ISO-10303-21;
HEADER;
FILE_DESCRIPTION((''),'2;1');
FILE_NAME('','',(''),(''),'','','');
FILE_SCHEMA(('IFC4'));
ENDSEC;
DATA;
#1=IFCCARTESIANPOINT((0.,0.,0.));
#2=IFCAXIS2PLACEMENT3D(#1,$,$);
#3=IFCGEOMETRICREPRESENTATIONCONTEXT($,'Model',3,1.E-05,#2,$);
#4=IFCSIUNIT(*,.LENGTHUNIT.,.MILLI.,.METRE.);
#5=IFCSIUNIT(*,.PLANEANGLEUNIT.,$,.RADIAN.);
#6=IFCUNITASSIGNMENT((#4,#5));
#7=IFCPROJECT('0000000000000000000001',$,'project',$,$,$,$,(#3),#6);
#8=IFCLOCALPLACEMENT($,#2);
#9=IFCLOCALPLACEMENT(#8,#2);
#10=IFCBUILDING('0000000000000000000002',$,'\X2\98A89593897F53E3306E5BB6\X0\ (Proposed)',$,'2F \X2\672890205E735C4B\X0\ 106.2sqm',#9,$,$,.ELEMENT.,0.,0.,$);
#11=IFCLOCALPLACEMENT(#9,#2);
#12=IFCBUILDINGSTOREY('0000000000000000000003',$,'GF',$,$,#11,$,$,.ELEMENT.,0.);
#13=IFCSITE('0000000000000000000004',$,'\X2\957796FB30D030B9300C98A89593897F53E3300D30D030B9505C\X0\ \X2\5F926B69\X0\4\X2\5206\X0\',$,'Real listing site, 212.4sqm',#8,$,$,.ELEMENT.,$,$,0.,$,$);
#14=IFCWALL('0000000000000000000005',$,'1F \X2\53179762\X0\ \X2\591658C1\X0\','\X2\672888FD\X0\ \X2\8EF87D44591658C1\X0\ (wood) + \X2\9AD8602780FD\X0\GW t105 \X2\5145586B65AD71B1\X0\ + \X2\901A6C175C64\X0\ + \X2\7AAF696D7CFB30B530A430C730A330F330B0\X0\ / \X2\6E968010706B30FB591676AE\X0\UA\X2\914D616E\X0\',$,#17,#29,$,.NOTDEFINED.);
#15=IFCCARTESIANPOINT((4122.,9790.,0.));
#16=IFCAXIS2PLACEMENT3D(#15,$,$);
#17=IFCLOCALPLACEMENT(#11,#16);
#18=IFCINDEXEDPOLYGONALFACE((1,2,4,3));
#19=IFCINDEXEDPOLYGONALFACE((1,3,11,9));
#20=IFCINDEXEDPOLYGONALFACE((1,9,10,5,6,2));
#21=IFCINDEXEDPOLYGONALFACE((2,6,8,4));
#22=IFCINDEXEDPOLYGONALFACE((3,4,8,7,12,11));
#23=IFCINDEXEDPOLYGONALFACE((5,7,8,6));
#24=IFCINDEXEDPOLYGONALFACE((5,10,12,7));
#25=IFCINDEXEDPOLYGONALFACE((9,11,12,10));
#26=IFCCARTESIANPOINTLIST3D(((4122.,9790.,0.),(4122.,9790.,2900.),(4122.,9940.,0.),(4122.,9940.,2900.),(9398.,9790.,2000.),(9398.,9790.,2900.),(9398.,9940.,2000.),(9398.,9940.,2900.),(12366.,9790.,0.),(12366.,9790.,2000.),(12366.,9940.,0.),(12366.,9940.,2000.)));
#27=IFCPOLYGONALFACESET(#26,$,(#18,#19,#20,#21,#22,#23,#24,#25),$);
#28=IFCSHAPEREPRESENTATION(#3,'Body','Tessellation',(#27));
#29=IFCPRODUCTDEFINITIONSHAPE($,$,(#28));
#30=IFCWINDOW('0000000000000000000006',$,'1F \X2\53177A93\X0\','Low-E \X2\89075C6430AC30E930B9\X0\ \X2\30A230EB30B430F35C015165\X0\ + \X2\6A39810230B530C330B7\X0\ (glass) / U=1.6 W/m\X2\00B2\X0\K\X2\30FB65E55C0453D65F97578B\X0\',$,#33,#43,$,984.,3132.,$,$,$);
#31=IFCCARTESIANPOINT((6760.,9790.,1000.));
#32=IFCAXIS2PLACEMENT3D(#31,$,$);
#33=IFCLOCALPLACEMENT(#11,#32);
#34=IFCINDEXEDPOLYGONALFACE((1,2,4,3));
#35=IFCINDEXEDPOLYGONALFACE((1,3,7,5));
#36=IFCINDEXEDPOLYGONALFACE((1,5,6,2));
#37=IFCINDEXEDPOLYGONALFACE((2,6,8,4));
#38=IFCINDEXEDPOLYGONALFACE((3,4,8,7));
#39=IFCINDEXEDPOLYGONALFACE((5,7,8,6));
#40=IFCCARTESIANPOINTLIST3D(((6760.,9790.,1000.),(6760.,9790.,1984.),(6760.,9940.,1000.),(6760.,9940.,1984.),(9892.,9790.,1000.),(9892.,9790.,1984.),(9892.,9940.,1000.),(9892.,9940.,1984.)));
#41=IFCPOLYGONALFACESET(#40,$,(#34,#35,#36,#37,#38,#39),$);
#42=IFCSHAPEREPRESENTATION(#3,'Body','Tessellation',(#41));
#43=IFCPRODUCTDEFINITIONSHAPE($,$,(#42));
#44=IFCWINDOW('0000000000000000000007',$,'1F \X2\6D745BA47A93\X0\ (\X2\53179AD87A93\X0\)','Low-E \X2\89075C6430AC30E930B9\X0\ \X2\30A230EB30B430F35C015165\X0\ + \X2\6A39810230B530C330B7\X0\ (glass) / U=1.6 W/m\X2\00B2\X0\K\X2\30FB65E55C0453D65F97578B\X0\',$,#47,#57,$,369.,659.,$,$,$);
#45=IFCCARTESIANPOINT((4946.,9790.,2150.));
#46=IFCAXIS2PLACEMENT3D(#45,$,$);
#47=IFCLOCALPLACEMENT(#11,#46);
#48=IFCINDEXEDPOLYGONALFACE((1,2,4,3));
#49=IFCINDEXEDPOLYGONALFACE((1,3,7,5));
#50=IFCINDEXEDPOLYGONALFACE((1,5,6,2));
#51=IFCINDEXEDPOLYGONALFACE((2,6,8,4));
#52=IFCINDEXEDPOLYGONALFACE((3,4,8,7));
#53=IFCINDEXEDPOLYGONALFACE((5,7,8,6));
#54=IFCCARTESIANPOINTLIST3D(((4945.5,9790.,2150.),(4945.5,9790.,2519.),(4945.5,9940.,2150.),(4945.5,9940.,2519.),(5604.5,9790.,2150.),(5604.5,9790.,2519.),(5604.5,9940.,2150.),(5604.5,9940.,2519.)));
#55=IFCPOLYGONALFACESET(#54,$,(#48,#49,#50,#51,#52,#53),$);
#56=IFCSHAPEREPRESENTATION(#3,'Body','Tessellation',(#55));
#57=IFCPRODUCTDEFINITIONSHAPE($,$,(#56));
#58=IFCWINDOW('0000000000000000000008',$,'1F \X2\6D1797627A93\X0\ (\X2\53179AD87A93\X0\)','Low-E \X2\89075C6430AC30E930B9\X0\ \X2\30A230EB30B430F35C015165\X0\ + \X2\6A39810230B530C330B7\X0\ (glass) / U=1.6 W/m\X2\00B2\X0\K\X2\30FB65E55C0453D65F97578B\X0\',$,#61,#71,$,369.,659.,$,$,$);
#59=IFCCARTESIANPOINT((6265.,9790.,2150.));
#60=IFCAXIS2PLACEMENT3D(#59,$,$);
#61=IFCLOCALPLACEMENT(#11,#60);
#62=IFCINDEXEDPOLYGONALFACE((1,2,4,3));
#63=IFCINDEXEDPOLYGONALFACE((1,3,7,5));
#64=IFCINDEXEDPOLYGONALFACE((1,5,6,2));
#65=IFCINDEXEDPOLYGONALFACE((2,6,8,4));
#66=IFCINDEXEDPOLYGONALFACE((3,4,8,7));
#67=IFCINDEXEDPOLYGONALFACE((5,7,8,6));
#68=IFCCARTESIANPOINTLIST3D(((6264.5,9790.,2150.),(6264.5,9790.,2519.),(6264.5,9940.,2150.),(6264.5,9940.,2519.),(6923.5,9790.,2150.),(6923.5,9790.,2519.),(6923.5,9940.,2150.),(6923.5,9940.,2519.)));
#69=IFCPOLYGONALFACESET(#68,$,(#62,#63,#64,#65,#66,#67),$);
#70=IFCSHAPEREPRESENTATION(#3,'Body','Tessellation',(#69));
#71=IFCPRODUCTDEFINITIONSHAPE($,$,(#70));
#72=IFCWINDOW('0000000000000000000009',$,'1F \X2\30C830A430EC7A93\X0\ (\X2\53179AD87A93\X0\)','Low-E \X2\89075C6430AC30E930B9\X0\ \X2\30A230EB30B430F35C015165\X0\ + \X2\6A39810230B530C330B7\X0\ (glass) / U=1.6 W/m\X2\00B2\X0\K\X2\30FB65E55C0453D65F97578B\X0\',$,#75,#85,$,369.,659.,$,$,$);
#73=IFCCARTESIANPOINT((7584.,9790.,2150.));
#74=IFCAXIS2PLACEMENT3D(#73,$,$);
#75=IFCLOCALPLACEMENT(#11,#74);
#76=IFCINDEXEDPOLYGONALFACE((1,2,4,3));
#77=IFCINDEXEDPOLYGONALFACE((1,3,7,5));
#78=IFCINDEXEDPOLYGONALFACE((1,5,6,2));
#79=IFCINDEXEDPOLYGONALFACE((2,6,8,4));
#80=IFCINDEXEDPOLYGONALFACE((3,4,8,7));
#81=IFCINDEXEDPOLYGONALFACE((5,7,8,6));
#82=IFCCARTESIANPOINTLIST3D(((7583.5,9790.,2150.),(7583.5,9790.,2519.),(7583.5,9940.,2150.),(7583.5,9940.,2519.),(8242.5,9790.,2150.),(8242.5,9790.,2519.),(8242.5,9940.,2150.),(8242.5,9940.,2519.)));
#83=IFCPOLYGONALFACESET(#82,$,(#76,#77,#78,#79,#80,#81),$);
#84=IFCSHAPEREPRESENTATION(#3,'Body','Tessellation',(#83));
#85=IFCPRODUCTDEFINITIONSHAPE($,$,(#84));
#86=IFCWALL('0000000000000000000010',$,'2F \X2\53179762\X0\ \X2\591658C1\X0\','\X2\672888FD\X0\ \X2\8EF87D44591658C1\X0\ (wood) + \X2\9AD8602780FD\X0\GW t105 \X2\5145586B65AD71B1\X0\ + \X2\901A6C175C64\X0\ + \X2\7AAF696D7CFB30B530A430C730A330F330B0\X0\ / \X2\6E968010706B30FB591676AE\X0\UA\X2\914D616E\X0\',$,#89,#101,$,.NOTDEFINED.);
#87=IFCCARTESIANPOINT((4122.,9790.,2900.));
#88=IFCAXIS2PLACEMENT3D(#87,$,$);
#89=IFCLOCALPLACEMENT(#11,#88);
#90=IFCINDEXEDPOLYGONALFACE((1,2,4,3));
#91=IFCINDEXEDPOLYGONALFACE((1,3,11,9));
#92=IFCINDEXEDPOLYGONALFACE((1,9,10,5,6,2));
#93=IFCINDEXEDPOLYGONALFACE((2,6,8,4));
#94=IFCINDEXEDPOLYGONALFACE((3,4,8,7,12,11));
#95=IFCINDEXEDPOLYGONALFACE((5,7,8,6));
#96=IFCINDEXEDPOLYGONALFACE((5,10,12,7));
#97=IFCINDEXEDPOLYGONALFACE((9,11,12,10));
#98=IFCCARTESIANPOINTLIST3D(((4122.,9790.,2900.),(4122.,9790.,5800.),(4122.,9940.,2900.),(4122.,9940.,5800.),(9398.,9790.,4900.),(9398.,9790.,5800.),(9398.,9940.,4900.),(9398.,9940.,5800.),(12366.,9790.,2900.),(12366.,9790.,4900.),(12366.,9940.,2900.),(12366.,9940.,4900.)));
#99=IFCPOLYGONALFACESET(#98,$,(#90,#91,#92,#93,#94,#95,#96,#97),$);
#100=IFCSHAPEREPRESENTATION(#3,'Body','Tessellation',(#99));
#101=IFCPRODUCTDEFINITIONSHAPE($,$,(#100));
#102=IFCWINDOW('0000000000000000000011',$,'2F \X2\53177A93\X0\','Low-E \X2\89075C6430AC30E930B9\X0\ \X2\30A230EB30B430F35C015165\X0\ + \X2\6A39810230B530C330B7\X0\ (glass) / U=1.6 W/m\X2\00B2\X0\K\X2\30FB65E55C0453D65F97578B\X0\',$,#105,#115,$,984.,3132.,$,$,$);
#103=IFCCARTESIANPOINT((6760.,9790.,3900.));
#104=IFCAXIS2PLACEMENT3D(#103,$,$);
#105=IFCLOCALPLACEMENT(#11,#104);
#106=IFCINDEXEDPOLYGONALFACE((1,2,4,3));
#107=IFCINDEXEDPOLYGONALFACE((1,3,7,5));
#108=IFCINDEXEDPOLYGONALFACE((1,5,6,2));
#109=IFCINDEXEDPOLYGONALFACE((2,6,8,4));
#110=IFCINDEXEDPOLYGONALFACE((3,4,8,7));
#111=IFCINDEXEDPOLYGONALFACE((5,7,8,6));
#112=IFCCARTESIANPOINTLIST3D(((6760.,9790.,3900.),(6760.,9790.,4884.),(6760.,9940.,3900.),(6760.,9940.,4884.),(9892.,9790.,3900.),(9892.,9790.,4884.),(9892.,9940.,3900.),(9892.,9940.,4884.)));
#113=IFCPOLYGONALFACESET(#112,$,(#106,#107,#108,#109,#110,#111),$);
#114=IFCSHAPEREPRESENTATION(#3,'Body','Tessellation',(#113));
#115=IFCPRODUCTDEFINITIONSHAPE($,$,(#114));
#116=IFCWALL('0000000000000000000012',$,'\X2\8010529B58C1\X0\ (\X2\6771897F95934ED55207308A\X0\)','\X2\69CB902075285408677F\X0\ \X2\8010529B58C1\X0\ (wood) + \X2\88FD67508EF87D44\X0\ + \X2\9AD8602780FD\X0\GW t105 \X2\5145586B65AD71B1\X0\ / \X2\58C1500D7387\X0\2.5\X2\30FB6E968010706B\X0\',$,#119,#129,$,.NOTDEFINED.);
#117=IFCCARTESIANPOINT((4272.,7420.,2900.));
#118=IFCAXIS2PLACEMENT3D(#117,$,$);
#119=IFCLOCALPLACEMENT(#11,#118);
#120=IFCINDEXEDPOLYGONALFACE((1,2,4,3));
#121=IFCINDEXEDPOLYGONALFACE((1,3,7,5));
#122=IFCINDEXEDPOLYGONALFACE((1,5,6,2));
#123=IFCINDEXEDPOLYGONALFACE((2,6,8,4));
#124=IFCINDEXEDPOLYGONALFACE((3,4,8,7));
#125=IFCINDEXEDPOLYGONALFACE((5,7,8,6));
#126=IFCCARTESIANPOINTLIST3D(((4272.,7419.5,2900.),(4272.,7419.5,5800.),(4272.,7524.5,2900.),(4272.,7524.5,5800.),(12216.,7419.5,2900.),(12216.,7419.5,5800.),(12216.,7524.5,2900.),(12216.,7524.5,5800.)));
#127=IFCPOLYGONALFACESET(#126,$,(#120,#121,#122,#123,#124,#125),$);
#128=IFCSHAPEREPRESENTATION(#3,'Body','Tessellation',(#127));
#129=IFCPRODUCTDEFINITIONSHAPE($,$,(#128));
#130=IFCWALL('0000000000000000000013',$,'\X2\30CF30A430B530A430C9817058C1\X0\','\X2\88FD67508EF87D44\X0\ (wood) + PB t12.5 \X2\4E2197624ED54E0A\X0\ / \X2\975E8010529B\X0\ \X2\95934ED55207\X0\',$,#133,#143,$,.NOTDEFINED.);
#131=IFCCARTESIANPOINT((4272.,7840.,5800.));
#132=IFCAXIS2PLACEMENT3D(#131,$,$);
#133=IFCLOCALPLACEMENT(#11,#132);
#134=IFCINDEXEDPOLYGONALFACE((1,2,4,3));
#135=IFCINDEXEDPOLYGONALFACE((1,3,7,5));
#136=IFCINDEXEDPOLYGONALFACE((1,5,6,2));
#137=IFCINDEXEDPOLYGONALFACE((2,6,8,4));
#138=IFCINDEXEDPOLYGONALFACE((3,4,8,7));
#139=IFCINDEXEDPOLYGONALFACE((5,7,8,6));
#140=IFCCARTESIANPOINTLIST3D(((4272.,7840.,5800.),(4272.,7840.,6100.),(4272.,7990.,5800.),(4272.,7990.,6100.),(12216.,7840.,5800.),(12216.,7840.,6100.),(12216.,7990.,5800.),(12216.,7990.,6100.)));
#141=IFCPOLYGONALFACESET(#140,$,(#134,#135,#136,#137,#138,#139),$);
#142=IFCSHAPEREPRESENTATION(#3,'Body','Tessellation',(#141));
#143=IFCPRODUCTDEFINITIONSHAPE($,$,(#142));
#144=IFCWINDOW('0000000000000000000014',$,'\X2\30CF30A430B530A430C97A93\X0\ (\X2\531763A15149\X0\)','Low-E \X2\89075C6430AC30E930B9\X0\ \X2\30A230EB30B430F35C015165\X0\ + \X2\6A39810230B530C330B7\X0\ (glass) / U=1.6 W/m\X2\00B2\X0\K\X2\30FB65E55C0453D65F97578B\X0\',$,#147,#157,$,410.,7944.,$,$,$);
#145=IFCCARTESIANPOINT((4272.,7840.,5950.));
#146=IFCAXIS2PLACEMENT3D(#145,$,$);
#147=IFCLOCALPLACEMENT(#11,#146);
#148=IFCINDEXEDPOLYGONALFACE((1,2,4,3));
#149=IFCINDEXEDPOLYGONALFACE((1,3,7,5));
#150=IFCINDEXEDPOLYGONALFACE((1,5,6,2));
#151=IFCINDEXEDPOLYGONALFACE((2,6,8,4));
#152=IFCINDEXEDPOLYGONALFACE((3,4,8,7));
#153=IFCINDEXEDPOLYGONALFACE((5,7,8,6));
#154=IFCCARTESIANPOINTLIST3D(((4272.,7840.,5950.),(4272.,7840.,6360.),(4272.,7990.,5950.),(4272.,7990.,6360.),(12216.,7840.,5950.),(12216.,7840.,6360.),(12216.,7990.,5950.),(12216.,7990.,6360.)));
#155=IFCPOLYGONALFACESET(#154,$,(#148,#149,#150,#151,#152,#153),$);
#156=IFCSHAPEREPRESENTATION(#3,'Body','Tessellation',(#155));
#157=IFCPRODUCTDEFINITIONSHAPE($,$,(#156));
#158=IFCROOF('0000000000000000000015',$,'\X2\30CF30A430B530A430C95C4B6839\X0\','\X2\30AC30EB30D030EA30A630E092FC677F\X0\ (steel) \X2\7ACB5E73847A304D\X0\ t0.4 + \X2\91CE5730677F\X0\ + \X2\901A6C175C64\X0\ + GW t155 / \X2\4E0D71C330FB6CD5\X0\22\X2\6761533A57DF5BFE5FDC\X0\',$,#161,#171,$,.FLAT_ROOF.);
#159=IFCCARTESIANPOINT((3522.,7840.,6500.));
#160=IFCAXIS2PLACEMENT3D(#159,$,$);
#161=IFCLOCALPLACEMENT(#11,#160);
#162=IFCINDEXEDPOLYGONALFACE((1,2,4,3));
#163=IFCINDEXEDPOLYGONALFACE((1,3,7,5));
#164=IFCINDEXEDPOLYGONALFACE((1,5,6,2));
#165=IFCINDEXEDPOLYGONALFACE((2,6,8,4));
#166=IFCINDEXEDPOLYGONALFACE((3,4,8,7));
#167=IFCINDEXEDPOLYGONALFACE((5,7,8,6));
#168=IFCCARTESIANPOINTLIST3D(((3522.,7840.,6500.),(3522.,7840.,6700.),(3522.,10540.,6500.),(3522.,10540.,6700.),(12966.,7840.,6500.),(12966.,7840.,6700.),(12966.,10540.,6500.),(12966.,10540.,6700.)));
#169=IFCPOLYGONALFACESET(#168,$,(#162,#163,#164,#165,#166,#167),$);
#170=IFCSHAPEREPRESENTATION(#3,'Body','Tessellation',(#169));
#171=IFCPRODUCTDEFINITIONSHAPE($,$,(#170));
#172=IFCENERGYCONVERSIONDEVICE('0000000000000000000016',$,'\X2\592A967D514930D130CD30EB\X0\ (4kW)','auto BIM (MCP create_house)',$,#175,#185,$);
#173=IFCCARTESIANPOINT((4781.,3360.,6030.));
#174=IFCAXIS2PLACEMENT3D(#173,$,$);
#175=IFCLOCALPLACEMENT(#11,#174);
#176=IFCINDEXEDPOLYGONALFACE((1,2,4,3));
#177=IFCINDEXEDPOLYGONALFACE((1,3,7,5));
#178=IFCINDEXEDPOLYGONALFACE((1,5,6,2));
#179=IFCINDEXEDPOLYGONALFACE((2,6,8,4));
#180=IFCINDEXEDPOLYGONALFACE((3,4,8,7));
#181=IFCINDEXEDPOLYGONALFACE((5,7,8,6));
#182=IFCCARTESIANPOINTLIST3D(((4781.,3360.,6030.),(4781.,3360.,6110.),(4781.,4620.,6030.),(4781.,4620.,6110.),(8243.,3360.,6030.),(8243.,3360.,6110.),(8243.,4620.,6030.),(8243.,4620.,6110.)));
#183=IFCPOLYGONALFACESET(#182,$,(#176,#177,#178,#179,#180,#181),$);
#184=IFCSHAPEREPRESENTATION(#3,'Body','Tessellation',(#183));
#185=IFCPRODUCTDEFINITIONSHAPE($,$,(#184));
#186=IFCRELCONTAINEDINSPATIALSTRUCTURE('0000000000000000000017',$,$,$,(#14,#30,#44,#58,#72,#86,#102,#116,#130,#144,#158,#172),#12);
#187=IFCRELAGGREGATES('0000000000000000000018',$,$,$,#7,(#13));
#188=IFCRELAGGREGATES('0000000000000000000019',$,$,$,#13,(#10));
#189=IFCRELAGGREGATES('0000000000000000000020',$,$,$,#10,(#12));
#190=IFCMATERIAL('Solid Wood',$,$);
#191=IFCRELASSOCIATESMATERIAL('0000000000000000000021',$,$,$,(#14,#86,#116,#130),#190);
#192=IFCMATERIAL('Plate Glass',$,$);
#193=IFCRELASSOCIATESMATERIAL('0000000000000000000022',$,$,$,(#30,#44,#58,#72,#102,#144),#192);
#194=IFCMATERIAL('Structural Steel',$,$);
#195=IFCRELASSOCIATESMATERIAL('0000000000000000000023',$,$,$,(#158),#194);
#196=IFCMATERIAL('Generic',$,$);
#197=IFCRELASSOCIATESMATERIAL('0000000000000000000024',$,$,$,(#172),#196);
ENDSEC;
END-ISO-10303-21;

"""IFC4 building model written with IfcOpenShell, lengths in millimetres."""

from ifc_helpers import new_model, si_unit, frame, frame_2d, origin, place, context, project, spatial, rectangle, extrude, material, element, fill, save


model = new_model("IFC4")

# Units and contexts
model_context = context("Model", 3, precision=1e-05, world=origin())
ifc_project = project(units=[si_unit("LENGTHUNIT", "METRE", prefix="MILLI"), si_unit("PLANEANGLEUNIT", "RADIAN")], contexts=[model_context])

# Site, building, storey
site_placement = place(None, origin())
site = spatial("IfcSite", under=ifc_project, at=site_placement, Name="長電バス「風間西口」バス停 徒歩4分", ObjectType="Real listing site, 212.4sqm", CompositionType="ELEMENT", RefElevation=0.0)
building_placement = place(site_placement, origin())
building = spatial("IfcBuilding", under=site, at=building_placement, Name="風間西口の家 (Proposed)", ObjectType="2F 木造平屋 106.2sqm", CompositionType="ELEMENT", ElevationOfRefHeight=0.0, ElevationOfTerrain=0.0)
storey_placement = place(building_placement, origin())
storey = spatial("IfcBuildingStorey", under=building, at=storey_placement, Name="GF", CompositionType="ELEMENT", Elevation=0.0)

# Wall, openings, windows
ifc_material_1 = material(Name="Solid Wood")
wall_1_placement = place(storey_placement, frame((4122.0, 9790.0, 0.0)))
wall_1 = element("IfcWall", 1, at=wall_1_placement, inside=storey, material=ifc_material_1, Name="1F 北面 外壁", Description="木製 軸組外壁 (wood) + 高性能GW t105 充填断熱 + 通気層 + 窯業系サイディング / 準耐火・外皮UA配慮", PredefinedType="NOTDEFINED", context=model_context, shape_type="SweptSolid", body=[
    extrude(rectangle(XDim=8244.0, YDim=150.0, at=frame_2d((4122.0, 75.0))), frame((4122.0, 9790.0, 0.0)), (0.0, 0.0, 1.0), 2900.0),
])
opening_1_placement = place(storey_placement, frame((6760.0, 9790.0, 1000.0)))
opening_1 = element("IfcOpeningElement", 2, at=opening_1_placement, cuts=wall_1, PredefinedType="NOTDEFINED", context=model_context, shape_type="SweptSolid", body=[
    extrude(rectangle(XDim=3132.0, YDim=150.0, at=frame_2d((1566.0, 75.0))), frame((6760.0, 9790.0, 1000.0)), (0.0, 0.0, 1.0), 984.0),
])
opening_2_placement = place(storey_placement, frame((4946.0, 9790.0, 2150.0)))
opening_2 = element("IfcOpeningElement", 3, at=opening_2_placement, cuts=wall_1, PredefinedType="NOTDEFINED", context=model_context, shape_type="SweptSolid", body=[
    extrude(rectangle(XDim=659.0, YDim=150.0, at=frame_2d((329.0, 75.0))), frame((4946.0, 9790.0, 2150.0)), (0.0, 0.0, 1.0), 369.0),
])
opening_3_placement = place(storey_placement, frame((6265.0, 9790.0, 2150.0)))
opening_3 = element("IfcOpeningElement", 4, at=opening_3_placement, cuts=wall_1, PredefinedType="NOTDEFINED", context=model_context, shape_type="SweptSolid", body=[
    extrude(rectangle(XDim=659.0, YDim=150.0, at=frame_2d((329.0, 75.0))), frame((6265.0, 9790.0, 2150.0)), (0.0, 0.0, 1.0), 369.0),
])
opening_4_placement = place(storey_placement, frame((7584.0, 9790.0, 2150.0)))
opening_4 = element("IfcOpeningElement", 5, at=opening_4_placement, cuts=wall_1, PredefinedType="NOTDEFINED", context=model_context, shape_type="SweptSolid", body=[
    extrude(rectangle(XDim=659.0, YDim=150.0, at=frame_2d((329.0, 75.0))), frame((7584.0, 9790.0, 2150.0)), (0.0, 0.0, 1.0), 369.0),
])
ifc_material_2 = material(Name="Plate Glass")
window_1_placement = place(storey_placement, frame((6760.0, 9790.0, 1000.0)))
window_1 = element("IfcWindow", 6, at=window_1_placement, inside=storey, material=ifc_material_2, Name="1F 北窓", Description="Low-E 複層ガラス アルゴン封入 + 樹脂サッシ (glass) / U=1.6 W/m²K・日射取得型", OverallHeight=984.0, OverallWidth=3132.0, context=model_context, shape_type="SweptSolid", body=[
    extrude(rectangle(XDim=3132.0, YDim=150.0, at=frame_2d((1566.0, 75.0))), frame((6760.0, 9790.0, 1000.0)), (0.0, 0.0, 1.0), 984.0),
])
fill(opening_1, window_1)
window_2_placement = place(storey_placement, frame((4946.0, 9790.0, 2150.0)))
window_2 = element("IfcWindow", 7, at=window_2_placement, inside=storey, material=ifc_material_2, Name="1F 浴室窓 (北高窓)", Description="Low-E 複層ガラス アルゴン封入 + 樹脂サッシ (glass) / U=1.6 W/m²K・日射取得型", OverallHeight=369.0, OverallWidth=659.0, context=model_context, shape_type="SweptSolid", body=[
    extrude(rectangle(XDim=659.0, YDim=150.0, at=frame_2d((329.0, 75.0))), frame((4946.0, 9790.0, 2150.0)), (0.0, 0.0, 1.0), 369.0),
])
fill(opening_2, window_2)
window_3_placement = place(storey_placement, frame((6265.0, 9790.0, 2150.0)))
window_3 = element("IfcWindow", 8, at=window_3_placement, inside=storey, material=ifc_material_2, Name="1F 洗面窓 (北高窓)", Description="Low-E 複層ガラス アルゴン封入 + 樹脂サッシ (glass) / U=1.6 W/m²K・日射取得型", OverallHeight=369.0, OverallWidth=659.0, context=model_context, shape_type="SweptSolid", body=[
    extrude(rectangle(XDim=659.0, YDim=150.0, at=frame_2d((329.0, 75.0))), frame((6265.0, 9790.0, 2150.0)), (0.0, 0.0, 1.0), 369.0),
])
fill(opening_3, window_3)
window_4_placement = place(storey_placement, frame((7584.0, 9790.0, 2150.0)))
window_4 = element("IfcWindow", 9, at=window_4_placement, inside=storey, material=ifc_material_2, Name="1F トイレ窓 (北高窓)", Description="Low-E 複層ガラス アルゴン封入 + 樹脂サッシ (glass) / U=1.6 W/m²K・日射取得型", OverallHeight=369.0, OverallWidth=659.0, context=model_context, shape_type="SweptSolid", body=[
    extrude(rectangle(XDim=659.0, YDim=150.0, at=frame_2d((329.0, 75.0))), frame((7584.0, 9790.0, 2150.0)), (0.0, 0.0, 1.0), 369.0),
])
fill(opening_4, window_4)

# Wall, opening, window
wall_2_placement = place(storey_placement, frame((4122.0, 9790.0, 2900.0)))
wall_2 = element("IfcWall", 10, at=wall_2_placement, inside=storey, material=ifc_material_1, Name="2F 北面 外壁", Description="木製 軸組外壁 (wood) + 高性能GW t105 充填断熱 + 通気層 + 窯業系サイディング / 準耐火・外皮UA配慮", PredefinedType="NOTDEFINED", context=model_context, shape_type="SweptSolid", body=[
    extrude(rectangle(XDim=8244.0, YDim=150.0, at=frame_2d((4122.0, 75.0))), frame((4122.0, 9790.0, 2900.0)), (0.0, 0.0, 1.0), 2900.0),
])
opening_5_placement = place(storey_placement, frame((6760.0, 9790.0, 3900.0)))
opening_5 = element("IfcOpeningElement", 11, at=opening_5_placement, cuts=wall_2, PredefinedType="NOTDEFINED", context=model_context, shape_type="SweptSolid", body=[
    extrude(rectangle(XDim=3132.0, YDim=150.0, at=frame_2d((1566.0, 75.0))), frame((6760.0, 9790.0, 3900.0)), (0.0, 0.0, 1.0), 984.0),
])
window_5_placement = place(storey_placement, frame((6760.0, 9790.0, 3900.0)))
window_5 = element("IfcWindow", 12, at=window_5_placement, inside=storey, material=ifc_material_2, Name="2F 北窓", Description="Low-E 複層ガラス アルゴン封入 + 樹脂サッシ (glass) / U=1.6 W/m²K・日射取得型", OverallHeight=984.0, OverallWidth=3132.0, context=model_context, shape_type="SweptSolid", body=[
    extrude(rectangle(XDim=3132.0, YDim=150.0, at=frame_2d((1566.0, 75.0))), frame((6760.0, 9790.0, 3900.0)), (0.0, 0.0, 1.0), 984.0),
])
fill(opening_5, window_5)

# Wall
wall_3_placement = place(storey_placement, frame((4272.0, 7420.0, 2900.0)))
element("IfcWall", 13, at=wall_3_placement, inside=storey, material=ifc_material_1, Name="耐力壁 (東西間仕切り)", Description="構造用合板 耐力壁 (wood) + 製材軸組 + 高性能GW t105 充填断熱 / 壁倍率2.5・準耐火", PredefinedType="NOTDEFINED", context=model_context, shape_type="SweptSolid", body=[
    extrude(rectangle(XDim=7944.0, YDim=105.0, at=frame_2d((3972.0, 52.0))), frame((4272.0, 7420.0, 2900.0)), (0.0, 0.0, 1.0), 2900.0),
])

# Wall, opening, window
wall_4_placement = place(storey_placement, frame((4272.0, 7840.0, 5800.0)))
wall_4 = element("IfcWall", 14, at=wall_4_placement, inside=storey, material=ifc_material_1, Name="ハイサイド腰壁", Description="製材軸組 (wood) + PB t12.5 両面仕上 / 非耐力 間仕切", PredefinedType="NOTDEFINED", context=model_context, shape_type="SweptSolid", body=[
    extrude(rectangle(XDim=7944.0, YDim=150.0, at=frame_2d((3972.0, 75.0))), frame((4272.0, 7840.0, 5800.0)), (0.0, 0.0, 1.0), 700.0),
])
opening_6_placement = place(storey_placement, frame((4272.0, 7840.0, 5950.0)))
opening_6 = element("IfcOpeningElement", 15, at=opening_6_placement, cuts=wall_4, PredefinedType="NOTDEFINED", context=model_context, shape_type="SweptSolid", body=[
    extrude(rectangle(XDim=7944.0, YDim=150.0, at=frame_2d((3972.0, 75.0))), frame((4272.0, 7840.0, 5950.0)), (0.0, 0.0, 1.0), 410.0),
])
window_6_placement = place(storey_placement, frame((4272.0, 7840.0, 5950.0)))
window_6 = element("IfcWindow", 16, at=window_6_placement, inside=storey, material=ifc_material_2, Name="ハイサイド窓 (北採光)", Description="Low-E 複層ガラス アルゴン封入 + 樹脂サッシ (glass) / U=1.6 W/m²K・日射取得型", OverallHeight=410.0, OverallWidth=7944.0, context=model_context, shape_type="SweptSolid", body=[
    extrude(rectangle(XDim=7944.0, YDim=150.0, at=frame_2d((3972.0, 75.0))), frame((4272.0, 7840.0, 5950.0)), (0.0, 0.0, 1.0), 410.0),
])
fill(opening_6, window_6)

# Roof
ifc_material_3 = material(Name="Structural Steel")
roof_placement = place(storey_placement, frame((3522.0, 7840.0, 6500.0)))
element("IfcRoof", 17, at=roof_placement, inside=storey, material=ifc_material_3, Name="ハイサイド屋根", Description="ガルバリウム鋼板 (steel) 立平葺き t0.4 + 野地板 + 通気層 + GW t155 / 不燃・法22条区域対応", PredefinedType="FLAT_ROOF", context=model_context, shape_type="SweptSolid", body=[
    extrude(rectangle(XDim=9444.0, YDim=2700.0, at=frame_2d((4722.0, 1350.0))), frame((3522.0, 7840.0, 6500.0)), (0.0, 0.0, 1.0), 200.0),
])

# Energy conversion device
ifc_material_4 = material(Name="Generic")
energy_conversion_device_placement = place(storey_placement, frame((4781.0, 3360.0, 6030.0)))
element("IfcEnergyConversionDevice", 18, at=energy_conversion_device_placement, inside=storey, material=ifc_material_4, Name="太陽光パネル (4kW)", Description="auto BIM (MCP create_house)", context=model_context, shape_type="SweptSolid", body=[
    extrude(rectangle(XDim=3462.0, YDim=1260.0, at=frame_2d((1731.0, 630.0))), frame((4781.0, 3360.0, 6030.0)), (0.0, 0.0, 1.0), 80.0),
])

save(model, "model.ifc")
